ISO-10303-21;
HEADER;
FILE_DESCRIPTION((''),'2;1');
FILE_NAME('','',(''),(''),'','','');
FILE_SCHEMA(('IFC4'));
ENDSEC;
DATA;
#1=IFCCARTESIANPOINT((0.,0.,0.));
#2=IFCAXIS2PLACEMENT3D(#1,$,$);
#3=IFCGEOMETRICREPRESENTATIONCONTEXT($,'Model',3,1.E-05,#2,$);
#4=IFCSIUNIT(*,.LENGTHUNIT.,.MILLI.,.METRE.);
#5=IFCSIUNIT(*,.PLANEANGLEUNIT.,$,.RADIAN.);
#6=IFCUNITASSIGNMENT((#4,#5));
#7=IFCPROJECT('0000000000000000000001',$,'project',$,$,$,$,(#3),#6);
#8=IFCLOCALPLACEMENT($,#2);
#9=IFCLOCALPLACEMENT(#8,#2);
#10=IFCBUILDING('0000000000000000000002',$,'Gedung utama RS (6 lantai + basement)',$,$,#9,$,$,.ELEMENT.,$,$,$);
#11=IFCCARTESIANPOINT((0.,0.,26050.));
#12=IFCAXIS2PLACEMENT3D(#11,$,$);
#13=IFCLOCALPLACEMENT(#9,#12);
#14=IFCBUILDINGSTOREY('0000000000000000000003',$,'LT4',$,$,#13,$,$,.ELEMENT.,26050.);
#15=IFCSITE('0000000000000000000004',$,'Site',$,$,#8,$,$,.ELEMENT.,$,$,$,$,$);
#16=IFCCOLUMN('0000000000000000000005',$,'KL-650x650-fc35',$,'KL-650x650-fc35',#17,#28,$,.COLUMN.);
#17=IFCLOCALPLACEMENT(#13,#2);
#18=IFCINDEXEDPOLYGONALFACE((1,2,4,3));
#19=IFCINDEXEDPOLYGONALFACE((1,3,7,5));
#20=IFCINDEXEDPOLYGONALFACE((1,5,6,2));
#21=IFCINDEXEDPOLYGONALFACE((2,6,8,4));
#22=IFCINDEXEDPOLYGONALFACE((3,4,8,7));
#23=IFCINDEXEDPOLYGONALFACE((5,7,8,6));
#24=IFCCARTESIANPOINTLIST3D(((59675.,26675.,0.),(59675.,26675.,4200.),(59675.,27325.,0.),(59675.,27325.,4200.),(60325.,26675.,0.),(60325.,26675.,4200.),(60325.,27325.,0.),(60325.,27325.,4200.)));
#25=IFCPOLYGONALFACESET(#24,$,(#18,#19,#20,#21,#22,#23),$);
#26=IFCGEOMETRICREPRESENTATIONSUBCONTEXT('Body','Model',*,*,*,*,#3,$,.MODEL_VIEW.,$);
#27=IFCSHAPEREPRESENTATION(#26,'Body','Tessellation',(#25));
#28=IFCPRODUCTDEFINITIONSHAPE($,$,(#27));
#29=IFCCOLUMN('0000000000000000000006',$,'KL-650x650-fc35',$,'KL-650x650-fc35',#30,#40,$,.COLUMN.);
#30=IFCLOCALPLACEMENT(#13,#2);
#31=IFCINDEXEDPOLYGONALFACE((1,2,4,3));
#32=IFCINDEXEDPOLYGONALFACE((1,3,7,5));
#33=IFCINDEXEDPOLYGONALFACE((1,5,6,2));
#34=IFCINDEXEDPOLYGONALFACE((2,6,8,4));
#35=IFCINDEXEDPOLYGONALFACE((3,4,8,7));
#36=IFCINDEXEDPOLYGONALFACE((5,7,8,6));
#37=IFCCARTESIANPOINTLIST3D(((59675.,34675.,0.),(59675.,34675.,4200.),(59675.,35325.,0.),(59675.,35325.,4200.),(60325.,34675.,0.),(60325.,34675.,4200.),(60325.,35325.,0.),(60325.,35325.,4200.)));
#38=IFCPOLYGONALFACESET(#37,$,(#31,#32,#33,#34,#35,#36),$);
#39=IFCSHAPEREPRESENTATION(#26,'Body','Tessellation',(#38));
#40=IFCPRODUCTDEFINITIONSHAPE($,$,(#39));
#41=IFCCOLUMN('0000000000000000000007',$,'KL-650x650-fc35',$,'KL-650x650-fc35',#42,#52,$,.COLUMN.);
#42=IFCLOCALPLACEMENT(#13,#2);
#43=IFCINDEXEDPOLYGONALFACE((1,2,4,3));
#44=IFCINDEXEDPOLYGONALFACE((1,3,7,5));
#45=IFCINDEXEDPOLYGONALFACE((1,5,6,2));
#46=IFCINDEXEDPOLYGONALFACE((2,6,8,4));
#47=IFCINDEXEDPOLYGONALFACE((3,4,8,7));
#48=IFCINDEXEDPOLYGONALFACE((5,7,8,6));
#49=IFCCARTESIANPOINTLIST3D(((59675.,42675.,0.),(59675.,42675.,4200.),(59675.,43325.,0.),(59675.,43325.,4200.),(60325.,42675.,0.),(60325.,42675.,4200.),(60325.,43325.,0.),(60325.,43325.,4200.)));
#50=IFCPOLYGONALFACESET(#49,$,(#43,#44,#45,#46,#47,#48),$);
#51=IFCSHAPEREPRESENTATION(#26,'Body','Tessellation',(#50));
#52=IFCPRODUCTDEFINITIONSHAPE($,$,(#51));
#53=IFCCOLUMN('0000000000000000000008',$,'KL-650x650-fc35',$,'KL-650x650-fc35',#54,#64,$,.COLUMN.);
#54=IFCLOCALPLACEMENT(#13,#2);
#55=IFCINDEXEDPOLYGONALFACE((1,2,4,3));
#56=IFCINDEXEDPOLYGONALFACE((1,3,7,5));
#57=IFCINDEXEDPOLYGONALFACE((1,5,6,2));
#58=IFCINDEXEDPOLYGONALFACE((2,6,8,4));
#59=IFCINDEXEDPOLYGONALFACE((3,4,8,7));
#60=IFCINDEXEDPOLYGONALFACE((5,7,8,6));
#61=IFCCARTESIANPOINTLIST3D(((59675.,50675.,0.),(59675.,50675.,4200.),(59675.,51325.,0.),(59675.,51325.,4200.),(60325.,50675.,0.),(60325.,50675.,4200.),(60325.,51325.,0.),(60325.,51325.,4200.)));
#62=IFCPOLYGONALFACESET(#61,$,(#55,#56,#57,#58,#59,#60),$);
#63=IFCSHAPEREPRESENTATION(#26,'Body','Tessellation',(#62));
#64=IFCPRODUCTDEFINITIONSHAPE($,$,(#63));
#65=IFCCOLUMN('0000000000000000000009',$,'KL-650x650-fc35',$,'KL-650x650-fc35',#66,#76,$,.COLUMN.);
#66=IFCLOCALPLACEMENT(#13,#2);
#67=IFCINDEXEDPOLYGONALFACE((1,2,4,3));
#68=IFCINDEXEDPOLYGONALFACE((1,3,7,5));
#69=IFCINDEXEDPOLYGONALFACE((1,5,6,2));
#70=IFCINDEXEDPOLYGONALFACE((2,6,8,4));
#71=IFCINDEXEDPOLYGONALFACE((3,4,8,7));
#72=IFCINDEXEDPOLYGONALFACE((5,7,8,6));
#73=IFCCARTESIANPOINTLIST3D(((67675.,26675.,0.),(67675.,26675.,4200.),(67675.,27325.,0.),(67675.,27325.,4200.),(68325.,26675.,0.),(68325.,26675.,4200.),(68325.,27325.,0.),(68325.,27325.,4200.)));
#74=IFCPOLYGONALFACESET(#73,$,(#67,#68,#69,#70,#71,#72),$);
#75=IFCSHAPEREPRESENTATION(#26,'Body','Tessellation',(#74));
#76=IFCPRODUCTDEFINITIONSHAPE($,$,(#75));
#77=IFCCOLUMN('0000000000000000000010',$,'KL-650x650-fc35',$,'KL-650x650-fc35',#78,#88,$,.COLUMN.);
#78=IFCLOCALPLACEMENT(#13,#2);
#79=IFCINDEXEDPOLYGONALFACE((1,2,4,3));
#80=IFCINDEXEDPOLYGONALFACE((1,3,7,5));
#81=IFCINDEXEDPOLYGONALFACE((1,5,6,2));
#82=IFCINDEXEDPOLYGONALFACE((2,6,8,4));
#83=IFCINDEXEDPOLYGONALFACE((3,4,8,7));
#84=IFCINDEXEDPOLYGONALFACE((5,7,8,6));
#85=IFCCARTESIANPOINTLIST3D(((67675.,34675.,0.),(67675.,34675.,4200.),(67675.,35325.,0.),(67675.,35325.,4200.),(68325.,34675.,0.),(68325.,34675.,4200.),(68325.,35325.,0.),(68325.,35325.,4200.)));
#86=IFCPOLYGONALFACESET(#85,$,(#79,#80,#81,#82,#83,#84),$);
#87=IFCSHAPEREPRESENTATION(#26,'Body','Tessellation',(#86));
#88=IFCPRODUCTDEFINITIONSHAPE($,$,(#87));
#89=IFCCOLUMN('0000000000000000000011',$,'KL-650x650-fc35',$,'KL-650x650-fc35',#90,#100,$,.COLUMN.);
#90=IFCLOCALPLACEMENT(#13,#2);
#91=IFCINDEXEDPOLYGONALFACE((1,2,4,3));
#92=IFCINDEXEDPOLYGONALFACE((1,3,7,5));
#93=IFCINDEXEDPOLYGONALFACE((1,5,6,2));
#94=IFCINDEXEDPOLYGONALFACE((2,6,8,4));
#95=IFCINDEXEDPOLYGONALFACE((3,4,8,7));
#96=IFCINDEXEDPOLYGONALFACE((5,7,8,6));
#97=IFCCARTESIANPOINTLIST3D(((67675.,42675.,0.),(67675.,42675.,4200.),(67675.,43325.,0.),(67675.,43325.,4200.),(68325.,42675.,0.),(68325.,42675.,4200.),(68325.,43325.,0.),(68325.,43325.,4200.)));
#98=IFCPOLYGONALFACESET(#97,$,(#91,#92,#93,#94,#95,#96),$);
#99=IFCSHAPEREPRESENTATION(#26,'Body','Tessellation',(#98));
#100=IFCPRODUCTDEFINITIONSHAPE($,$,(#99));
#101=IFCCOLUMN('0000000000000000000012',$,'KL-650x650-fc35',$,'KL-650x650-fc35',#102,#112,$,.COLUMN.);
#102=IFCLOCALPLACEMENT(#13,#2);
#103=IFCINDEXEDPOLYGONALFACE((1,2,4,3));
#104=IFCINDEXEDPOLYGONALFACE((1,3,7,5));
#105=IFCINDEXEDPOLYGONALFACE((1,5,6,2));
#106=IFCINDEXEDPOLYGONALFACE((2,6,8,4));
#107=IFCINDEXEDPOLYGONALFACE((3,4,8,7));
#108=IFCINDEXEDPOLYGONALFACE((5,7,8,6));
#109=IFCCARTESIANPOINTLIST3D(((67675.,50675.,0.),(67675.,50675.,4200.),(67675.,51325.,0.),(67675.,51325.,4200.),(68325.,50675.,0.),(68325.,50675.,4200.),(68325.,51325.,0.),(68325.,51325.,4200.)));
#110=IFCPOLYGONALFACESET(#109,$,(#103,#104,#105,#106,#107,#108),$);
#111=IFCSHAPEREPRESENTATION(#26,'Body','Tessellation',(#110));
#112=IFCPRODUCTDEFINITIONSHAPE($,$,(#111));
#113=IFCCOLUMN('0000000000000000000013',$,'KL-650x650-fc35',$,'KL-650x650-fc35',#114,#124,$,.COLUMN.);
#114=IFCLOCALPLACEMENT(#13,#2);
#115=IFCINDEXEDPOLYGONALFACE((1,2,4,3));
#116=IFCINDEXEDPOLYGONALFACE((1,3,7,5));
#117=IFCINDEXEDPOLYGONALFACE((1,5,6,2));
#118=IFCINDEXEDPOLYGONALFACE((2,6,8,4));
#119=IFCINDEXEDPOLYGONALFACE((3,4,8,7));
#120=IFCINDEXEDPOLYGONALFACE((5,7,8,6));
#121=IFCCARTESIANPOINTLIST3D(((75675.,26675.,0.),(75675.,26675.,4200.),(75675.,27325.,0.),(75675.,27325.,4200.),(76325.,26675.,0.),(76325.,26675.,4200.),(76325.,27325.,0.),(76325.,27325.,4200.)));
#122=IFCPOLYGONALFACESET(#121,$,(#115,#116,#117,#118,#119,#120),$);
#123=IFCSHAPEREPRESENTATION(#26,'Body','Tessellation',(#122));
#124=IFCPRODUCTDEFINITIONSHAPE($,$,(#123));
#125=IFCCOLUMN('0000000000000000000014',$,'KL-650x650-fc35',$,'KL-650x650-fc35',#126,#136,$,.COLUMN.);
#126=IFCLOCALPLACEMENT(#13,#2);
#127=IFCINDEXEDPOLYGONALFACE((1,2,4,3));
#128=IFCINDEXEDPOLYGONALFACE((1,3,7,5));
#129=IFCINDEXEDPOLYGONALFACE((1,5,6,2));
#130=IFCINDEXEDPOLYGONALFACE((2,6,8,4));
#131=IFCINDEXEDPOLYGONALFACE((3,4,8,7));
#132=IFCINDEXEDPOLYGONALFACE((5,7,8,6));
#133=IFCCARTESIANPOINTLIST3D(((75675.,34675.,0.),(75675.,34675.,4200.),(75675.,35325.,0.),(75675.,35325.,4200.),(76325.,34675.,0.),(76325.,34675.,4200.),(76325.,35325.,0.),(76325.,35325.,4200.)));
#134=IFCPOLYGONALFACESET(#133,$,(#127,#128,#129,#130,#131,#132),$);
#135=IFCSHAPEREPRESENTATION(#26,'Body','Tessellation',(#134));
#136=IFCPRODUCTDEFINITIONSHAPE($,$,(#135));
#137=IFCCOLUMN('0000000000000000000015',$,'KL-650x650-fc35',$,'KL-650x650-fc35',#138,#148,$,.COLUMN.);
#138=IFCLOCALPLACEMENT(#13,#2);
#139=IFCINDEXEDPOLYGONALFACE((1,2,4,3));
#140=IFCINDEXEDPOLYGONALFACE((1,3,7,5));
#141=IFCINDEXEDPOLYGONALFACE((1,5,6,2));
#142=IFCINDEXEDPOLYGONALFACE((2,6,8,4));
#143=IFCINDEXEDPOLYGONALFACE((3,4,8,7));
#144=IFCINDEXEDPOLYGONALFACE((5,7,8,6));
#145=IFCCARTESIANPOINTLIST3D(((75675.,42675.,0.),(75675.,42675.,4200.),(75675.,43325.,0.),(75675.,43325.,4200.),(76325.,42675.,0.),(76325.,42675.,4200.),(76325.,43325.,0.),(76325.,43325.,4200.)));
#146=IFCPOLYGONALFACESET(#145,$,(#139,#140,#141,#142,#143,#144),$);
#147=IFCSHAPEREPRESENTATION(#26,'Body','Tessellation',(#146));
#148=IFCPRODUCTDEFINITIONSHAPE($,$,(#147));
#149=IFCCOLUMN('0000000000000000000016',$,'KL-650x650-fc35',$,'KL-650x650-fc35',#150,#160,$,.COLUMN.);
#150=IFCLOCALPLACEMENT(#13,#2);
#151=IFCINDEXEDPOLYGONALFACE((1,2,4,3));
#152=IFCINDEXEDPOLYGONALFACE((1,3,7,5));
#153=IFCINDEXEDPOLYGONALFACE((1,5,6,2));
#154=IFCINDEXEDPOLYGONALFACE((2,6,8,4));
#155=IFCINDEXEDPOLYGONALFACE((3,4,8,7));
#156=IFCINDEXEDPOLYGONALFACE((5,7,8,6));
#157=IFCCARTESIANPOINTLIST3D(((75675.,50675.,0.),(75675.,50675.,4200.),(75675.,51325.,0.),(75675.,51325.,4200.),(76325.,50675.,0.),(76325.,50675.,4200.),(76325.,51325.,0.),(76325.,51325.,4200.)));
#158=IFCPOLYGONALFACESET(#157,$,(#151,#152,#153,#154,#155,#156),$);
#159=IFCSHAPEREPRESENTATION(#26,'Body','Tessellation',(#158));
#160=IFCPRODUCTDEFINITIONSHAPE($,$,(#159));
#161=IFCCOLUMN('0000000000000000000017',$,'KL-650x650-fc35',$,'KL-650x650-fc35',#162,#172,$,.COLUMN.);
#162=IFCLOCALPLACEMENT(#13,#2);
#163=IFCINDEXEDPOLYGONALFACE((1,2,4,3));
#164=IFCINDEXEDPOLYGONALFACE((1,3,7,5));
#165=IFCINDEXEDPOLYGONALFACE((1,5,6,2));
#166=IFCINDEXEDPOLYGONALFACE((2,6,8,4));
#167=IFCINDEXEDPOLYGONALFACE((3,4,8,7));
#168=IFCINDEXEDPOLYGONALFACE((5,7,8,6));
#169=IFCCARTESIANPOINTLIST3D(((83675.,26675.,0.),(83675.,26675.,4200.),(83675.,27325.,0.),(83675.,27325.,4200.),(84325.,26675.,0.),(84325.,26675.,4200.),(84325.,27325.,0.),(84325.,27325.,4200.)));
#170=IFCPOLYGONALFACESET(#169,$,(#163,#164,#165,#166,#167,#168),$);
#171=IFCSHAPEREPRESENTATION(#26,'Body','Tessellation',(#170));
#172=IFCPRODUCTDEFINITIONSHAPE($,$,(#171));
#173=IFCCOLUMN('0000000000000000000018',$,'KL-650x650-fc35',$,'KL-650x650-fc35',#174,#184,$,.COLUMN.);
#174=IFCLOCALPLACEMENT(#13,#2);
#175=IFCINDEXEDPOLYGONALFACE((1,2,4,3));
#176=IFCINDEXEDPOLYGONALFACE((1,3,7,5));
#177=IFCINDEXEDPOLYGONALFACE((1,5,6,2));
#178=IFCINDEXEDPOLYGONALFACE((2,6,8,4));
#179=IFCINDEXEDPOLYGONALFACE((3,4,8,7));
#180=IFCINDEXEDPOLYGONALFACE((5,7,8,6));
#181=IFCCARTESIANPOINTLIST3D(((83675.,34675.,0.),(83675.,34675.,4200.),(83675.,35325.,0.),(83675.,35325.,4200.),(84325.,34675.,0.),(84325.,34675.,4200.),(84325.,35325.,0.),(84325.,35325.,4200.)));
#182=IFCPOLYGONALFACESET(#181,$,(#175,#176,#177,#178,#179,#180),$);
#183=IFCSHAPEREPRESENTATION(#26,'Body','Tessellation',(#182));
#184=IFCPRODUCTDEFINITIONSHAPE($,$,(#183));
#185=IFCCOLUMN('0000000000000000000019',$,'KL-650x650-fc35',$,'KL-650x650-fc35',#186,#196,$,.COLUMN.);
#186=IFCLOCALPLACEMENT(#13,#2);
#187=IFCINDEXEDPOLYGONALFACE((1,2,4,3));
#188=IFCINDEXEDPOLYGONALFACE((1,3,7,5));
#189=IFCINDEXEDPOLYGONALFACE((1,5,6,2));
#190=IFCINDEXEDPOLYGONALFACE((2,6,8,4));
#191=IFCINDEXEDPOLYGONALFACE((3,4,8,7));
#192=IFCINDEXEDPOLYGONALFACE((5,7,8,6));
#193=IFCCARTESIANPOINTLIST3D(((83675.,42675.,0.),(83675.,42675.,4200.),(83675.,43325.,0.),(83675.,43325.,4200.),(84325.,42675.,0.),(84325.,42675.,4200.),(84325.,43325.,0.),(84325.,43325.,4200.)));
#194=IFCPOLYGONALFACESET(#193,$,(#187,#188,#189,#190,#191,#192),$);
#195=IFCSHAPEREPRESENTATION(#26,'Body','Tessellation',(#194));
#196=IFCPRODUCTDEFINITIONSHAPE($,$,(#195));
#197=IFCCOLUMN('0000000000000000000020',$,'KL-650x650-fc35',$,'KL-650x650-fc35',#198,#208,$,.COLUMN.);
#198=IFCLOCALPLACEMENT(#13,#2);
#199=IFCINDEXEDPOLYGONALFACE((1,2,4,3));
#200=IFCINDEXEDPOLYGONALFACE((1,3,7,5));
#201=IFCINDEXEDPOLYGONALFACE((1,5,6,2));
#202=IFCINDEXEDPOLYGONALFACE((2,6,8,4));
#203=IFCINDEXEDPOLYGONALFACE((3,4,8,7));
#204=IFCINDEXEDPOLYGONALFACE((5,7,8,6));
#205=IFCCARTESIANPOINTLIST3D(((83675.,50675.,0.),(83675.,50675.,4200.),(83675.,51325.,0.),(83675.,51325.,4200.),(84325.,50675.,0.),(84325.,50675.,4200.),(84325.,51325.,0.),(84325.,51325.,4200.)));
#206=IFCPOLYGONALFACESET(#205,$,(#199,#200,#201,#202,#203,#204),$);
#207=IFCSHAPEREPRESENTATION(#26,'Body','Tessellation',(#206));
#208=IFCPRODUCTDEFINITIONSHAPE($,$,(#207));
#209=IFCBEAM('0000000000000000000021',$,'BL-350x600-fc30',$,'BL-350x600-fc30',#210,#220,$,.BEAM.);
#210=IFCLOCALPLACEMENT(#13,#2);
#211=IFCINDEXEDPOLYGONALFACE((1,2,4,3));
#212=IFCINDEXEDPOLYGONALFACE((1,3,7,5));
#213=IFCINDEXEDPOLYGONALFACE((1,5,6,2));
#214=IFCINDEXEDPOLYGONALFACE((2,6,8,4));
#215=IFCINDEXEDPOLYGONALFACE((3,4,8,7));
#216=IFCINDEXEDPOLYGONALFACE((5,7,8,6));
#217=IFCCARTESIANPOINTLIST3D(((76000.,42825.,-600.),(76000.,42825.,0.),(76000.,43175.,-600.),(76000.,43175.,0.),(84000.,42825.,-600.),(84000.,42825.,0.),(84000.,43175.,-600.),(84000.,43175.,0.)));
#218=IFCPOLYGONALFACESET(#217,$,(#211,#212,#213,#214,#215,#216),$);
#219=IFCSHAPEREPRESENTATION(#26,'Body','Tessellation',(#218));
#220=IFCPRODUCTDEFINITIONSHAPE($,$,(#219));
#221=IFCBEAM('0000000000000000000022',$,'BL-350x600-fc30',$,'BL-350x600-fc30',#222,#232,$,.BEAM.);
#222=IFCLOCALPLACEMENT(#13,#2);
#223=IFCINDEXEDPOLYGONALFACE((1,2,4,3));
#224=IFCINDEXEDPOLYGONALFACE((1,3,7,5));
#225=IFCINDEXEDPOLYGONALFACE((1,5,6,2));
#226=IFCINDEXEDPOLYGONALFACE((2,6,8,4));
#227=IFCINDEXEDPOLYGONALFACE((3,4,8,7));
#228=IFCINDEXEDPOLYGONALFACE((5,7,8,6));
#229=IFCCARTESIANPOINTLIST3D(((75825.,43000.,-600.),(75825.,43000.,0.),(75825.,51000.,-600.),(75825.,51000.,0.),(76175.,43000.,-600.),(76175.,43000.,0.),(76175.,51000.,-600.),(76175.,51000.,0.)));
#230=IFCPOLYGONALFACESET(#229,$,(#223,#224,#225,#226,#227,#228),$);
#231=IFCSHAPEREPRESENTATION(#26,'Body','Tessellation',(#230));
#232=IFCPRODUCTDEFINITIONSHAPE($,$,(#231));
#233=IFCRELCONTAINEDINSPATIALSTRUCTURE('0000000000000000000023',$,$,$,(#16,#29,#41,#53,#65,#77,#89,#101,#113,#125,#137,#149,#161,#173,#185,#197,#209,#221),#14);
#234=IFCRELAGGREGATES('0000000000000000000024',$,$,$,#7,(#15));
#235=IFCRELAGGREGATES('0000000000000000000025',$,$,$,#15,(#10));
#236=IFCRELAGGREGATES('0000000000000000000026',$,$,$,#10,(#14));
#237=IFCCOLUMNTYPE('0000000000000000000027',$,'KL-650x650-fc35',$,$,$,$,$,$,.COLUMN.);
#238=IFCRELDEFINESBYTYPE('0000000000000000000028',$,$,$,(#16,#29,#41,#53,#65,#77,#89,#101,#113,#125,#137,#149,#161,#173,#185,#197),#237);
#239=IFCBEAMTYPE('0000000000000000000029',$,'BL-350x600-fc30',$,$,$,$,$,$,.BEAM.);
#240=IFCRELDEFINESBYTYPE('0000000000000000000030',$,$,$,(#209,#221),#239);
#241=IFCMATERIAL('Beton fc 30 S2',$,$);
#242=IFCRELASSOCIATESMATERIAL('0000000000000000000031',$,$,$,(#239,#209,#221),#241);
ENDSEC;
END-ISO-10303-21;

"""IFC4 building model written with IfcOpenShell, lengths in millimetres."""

from ifc_helpers import new_model, si_unit, frame, origin, origin_2d, place, context, subcontext, project, spatial, rectangle, extrude, material, material_profile, profile_set, profile_usage, type_object, element, save


model = new_model("IFC4")

# Units and contexts
model_context = context("Model", 3, precision=1e-05, world=origin())
body_context = subcontext(model_context, "Body", "Model", "MODEL_VIEW")
ifc_project = project(units=[si_unit("LENGTHUNIT", "METRE", prefix="MILLI"), si_unit("PLANEANGLEUNIT", "RADIAN")], contexts=[model_context])

# Site, building, storey
site_placement = place(None, origin())
site = spatial("IfcSite", under=ifc_project, at=site_placement, Name="Site", CompositionType="ELEMENT")
building_placement = place(site_placement, origin())
building = spatial("IfcBuilding", under=site, at=building_placement, Name="Gedung utama RS (6 lantai + basement)", CompositionType="ELEMENT")
storey_placement = place(building_placement, frame((0.0, 0.0, 26050.0)))
storey = spatial("IfcBuildingStorey", under=building, at=storey_placement, Name="LT4", CompositionType="ELEMENT", Elevation=26050.0)

# Columns
ifc_material_profile_1 = material_profile(None, rectangle(XDim=650.0, YDim=650.0, at=origin_2d()), Name="KL-650x650-fc35")
ifc_profile_set_1 = profile_set([ifc_material_profile_1], Name="KL-650x650-fc35")
ifc_profile_usage_1 = profile_usage(ifc_profile_set_1, cardinal=5)
column_type = type_object("IfcColumnType", Name="KL-650x650-fc35", PredefinedType="COLUMN", material=ifc_profile_set_1)
for number, where, z_axis, x_axis, name in (
    (1, (60000.0, 27000.0, 0.0), (0.0, 0.0, 1.0), (1.0, 0.0, 0.0), "KL-650x650-fc35"),
    (2, (60000.0, 35000.0, 0.0), (0.0, 0.0, 1.0), (1.0, 0.0, 0.0), "KL-650x650-fc35"),
    (3, (60000.0, 43000.0, 0.0), (0.0, 0.0, 1.0), (1.0, 0.0, 0.0), "KL-650x650-fc35"),
    (4, (60000.0, 51000.0, 0.0), (0.0, 0.0, 1.0), (1.0, 0.0, 0.0), "KL-650x650-fc35"),
    (5, (68000.0, 27000.0, 0.0), (0.0, 0.0, 1.0), (1.0, 0.0, 0.0), "KL-650x650-fc35"),
    (6, (68000.0, 35000.0, 0.0), (0.0, 0.0, 1.0), (1.0, 0.0, 0.0), "KL-650x650-fc35"),
    (7, (68000.0, 43000.0, 0.0), (0.0, 0.0, 1.0), (1.0, 0.0, 0.0), "KL-650x650-fc35"),
    (8, (68000.0, 51000.0, 0.0), (0.0, 0.0, 1.0), (1.0, 0.0, 0.0), "KL-650x650-fc35"),
    (9, (76000.0, 27000.0, 0.0), (0.0, 0.0, 1.0), (1.0, 0.0, 0.0), "KL-650x650-fc35"),
    (10, (76000.0, 35000.0, 0.0), (0.0, 0.0, 1.0), (1.0, 0.0, 0.0), "KL-650x650-fc35"),
    (11, (76000.0, 43000.0, 0.0), (0.0, 0.0, 1.0), (1.0, 0.0, 0.0), "KL-650x650-fc35"),
    (12, (76000.0, 51000.0, 0.0), (0.0, 0.0, 1.0), (1.0, 0.0, 0.0), "KL-650x650-fc35"),
    (13, (84000.0, 27000.0, 0.0), (0.0, 0.0, 1.0), (1.0, 0.0, 0.0), "KL-650x650-fc35"),
    (14, (84000.0, 35000.0, 0.0), (0.0, 0.0, 1.0), (1.0, 0.0, 0.0), "KL-650x650-fc35"),
    (15, (84000.0, 43000.0, 0.0), (0.0, 0.0, 1.0), (1.0, 0.0, 0.0), "KL-650x650-fc35"),
    (16, (84000.0, 51000.0, 0.0), (0.0, 0.0, 1.0), (1.0, 0.0, 0.0), "KL-650x650-fc35"),
):
    element("IfcColumn", number, at=place(storey_placement, frame(where, z_axis=z_axis, x_axis=x_axis)), inside=storey, type_object=column_type, material=ifc_profile_usage_1, Name=name, ObjectType="KL-650x650-fc35", PredefinedType="COLUMN", context=body_context, shape_type="SweptSolid", body=[
        extrude(rectangle(XDim=650.0, YDim=650.0, at=origin_2d()), origin(), (0.0, 0.0, 1.0), 4200.0),
    ])

# Beams
ifc_material_1 = material(Name="Beton fc 30 S2")
ifc_material_profile_2 = material_profile(ifc_material_1, rectangle(XDim=350.0, YDim=600.0, at=origin_2d()), Name="BL-350x600-fc30")
ifc_profile_set_2 = profile_set([ifc_material_profile_2], Name="BL-350x600-fc30")
ifc_profile_usage_2 = profile_usage(ifc_profile_set_2, cardinal=8)
beam_type = type_object("IfcBeamType", Name="BL-350x600-fc30", PredefinedType="BEAM", material=ifc_profile_set_2)
beam_1_placement = place(storey_placement, frame((76000.0, 43000.0, -300.0)))
element("IfcBeam", 17, at=beam_1_placement, inside=storey, type_object=beam_type, material=ifc_profile_usage_2, Name="BL-350x600-fc30", ObjectType="BL-350x600-fc30", PredefinedType="BEAM", context=body_context, shape_type="SweptSolid", body=[
    extrude(rectangle(XDim=350.0, YDim=600.0, at=origin_2d()), frame((0.0, 0.0, 0.0), z_axis=(1.0, 0.0, 0.0), x_axis=(0.0, 1.0, 0.0)), (0.0, 0.0, 1.0), 8000.0),
])
beam_2_placement = place(storey_placement, frame((76000.0, 43000.0, -300.0)))
element("IfcBeam", 18, at=beam_2_placement, inside=storey, type_object=beam_type, material=ifc_profile_usage_2, Name="BL-350x600-fc30", ObjectType="BL-350x600-fc30", PredefinedType="BEAM", context=body_context, shape_type="SweptSolid", body=[
    extrude(rectangle(XDim=350.0, YDim=600.0, at=origin_2d()), frame((0.0, 0.0, 0.0), z_axis=(0.0, 1.0, 0.0), x_axis=(-1.0, 0.0, 0.0)), (0.0, 0.0, 1.0), 8000.0),
])

save(model, "model.ifc")
